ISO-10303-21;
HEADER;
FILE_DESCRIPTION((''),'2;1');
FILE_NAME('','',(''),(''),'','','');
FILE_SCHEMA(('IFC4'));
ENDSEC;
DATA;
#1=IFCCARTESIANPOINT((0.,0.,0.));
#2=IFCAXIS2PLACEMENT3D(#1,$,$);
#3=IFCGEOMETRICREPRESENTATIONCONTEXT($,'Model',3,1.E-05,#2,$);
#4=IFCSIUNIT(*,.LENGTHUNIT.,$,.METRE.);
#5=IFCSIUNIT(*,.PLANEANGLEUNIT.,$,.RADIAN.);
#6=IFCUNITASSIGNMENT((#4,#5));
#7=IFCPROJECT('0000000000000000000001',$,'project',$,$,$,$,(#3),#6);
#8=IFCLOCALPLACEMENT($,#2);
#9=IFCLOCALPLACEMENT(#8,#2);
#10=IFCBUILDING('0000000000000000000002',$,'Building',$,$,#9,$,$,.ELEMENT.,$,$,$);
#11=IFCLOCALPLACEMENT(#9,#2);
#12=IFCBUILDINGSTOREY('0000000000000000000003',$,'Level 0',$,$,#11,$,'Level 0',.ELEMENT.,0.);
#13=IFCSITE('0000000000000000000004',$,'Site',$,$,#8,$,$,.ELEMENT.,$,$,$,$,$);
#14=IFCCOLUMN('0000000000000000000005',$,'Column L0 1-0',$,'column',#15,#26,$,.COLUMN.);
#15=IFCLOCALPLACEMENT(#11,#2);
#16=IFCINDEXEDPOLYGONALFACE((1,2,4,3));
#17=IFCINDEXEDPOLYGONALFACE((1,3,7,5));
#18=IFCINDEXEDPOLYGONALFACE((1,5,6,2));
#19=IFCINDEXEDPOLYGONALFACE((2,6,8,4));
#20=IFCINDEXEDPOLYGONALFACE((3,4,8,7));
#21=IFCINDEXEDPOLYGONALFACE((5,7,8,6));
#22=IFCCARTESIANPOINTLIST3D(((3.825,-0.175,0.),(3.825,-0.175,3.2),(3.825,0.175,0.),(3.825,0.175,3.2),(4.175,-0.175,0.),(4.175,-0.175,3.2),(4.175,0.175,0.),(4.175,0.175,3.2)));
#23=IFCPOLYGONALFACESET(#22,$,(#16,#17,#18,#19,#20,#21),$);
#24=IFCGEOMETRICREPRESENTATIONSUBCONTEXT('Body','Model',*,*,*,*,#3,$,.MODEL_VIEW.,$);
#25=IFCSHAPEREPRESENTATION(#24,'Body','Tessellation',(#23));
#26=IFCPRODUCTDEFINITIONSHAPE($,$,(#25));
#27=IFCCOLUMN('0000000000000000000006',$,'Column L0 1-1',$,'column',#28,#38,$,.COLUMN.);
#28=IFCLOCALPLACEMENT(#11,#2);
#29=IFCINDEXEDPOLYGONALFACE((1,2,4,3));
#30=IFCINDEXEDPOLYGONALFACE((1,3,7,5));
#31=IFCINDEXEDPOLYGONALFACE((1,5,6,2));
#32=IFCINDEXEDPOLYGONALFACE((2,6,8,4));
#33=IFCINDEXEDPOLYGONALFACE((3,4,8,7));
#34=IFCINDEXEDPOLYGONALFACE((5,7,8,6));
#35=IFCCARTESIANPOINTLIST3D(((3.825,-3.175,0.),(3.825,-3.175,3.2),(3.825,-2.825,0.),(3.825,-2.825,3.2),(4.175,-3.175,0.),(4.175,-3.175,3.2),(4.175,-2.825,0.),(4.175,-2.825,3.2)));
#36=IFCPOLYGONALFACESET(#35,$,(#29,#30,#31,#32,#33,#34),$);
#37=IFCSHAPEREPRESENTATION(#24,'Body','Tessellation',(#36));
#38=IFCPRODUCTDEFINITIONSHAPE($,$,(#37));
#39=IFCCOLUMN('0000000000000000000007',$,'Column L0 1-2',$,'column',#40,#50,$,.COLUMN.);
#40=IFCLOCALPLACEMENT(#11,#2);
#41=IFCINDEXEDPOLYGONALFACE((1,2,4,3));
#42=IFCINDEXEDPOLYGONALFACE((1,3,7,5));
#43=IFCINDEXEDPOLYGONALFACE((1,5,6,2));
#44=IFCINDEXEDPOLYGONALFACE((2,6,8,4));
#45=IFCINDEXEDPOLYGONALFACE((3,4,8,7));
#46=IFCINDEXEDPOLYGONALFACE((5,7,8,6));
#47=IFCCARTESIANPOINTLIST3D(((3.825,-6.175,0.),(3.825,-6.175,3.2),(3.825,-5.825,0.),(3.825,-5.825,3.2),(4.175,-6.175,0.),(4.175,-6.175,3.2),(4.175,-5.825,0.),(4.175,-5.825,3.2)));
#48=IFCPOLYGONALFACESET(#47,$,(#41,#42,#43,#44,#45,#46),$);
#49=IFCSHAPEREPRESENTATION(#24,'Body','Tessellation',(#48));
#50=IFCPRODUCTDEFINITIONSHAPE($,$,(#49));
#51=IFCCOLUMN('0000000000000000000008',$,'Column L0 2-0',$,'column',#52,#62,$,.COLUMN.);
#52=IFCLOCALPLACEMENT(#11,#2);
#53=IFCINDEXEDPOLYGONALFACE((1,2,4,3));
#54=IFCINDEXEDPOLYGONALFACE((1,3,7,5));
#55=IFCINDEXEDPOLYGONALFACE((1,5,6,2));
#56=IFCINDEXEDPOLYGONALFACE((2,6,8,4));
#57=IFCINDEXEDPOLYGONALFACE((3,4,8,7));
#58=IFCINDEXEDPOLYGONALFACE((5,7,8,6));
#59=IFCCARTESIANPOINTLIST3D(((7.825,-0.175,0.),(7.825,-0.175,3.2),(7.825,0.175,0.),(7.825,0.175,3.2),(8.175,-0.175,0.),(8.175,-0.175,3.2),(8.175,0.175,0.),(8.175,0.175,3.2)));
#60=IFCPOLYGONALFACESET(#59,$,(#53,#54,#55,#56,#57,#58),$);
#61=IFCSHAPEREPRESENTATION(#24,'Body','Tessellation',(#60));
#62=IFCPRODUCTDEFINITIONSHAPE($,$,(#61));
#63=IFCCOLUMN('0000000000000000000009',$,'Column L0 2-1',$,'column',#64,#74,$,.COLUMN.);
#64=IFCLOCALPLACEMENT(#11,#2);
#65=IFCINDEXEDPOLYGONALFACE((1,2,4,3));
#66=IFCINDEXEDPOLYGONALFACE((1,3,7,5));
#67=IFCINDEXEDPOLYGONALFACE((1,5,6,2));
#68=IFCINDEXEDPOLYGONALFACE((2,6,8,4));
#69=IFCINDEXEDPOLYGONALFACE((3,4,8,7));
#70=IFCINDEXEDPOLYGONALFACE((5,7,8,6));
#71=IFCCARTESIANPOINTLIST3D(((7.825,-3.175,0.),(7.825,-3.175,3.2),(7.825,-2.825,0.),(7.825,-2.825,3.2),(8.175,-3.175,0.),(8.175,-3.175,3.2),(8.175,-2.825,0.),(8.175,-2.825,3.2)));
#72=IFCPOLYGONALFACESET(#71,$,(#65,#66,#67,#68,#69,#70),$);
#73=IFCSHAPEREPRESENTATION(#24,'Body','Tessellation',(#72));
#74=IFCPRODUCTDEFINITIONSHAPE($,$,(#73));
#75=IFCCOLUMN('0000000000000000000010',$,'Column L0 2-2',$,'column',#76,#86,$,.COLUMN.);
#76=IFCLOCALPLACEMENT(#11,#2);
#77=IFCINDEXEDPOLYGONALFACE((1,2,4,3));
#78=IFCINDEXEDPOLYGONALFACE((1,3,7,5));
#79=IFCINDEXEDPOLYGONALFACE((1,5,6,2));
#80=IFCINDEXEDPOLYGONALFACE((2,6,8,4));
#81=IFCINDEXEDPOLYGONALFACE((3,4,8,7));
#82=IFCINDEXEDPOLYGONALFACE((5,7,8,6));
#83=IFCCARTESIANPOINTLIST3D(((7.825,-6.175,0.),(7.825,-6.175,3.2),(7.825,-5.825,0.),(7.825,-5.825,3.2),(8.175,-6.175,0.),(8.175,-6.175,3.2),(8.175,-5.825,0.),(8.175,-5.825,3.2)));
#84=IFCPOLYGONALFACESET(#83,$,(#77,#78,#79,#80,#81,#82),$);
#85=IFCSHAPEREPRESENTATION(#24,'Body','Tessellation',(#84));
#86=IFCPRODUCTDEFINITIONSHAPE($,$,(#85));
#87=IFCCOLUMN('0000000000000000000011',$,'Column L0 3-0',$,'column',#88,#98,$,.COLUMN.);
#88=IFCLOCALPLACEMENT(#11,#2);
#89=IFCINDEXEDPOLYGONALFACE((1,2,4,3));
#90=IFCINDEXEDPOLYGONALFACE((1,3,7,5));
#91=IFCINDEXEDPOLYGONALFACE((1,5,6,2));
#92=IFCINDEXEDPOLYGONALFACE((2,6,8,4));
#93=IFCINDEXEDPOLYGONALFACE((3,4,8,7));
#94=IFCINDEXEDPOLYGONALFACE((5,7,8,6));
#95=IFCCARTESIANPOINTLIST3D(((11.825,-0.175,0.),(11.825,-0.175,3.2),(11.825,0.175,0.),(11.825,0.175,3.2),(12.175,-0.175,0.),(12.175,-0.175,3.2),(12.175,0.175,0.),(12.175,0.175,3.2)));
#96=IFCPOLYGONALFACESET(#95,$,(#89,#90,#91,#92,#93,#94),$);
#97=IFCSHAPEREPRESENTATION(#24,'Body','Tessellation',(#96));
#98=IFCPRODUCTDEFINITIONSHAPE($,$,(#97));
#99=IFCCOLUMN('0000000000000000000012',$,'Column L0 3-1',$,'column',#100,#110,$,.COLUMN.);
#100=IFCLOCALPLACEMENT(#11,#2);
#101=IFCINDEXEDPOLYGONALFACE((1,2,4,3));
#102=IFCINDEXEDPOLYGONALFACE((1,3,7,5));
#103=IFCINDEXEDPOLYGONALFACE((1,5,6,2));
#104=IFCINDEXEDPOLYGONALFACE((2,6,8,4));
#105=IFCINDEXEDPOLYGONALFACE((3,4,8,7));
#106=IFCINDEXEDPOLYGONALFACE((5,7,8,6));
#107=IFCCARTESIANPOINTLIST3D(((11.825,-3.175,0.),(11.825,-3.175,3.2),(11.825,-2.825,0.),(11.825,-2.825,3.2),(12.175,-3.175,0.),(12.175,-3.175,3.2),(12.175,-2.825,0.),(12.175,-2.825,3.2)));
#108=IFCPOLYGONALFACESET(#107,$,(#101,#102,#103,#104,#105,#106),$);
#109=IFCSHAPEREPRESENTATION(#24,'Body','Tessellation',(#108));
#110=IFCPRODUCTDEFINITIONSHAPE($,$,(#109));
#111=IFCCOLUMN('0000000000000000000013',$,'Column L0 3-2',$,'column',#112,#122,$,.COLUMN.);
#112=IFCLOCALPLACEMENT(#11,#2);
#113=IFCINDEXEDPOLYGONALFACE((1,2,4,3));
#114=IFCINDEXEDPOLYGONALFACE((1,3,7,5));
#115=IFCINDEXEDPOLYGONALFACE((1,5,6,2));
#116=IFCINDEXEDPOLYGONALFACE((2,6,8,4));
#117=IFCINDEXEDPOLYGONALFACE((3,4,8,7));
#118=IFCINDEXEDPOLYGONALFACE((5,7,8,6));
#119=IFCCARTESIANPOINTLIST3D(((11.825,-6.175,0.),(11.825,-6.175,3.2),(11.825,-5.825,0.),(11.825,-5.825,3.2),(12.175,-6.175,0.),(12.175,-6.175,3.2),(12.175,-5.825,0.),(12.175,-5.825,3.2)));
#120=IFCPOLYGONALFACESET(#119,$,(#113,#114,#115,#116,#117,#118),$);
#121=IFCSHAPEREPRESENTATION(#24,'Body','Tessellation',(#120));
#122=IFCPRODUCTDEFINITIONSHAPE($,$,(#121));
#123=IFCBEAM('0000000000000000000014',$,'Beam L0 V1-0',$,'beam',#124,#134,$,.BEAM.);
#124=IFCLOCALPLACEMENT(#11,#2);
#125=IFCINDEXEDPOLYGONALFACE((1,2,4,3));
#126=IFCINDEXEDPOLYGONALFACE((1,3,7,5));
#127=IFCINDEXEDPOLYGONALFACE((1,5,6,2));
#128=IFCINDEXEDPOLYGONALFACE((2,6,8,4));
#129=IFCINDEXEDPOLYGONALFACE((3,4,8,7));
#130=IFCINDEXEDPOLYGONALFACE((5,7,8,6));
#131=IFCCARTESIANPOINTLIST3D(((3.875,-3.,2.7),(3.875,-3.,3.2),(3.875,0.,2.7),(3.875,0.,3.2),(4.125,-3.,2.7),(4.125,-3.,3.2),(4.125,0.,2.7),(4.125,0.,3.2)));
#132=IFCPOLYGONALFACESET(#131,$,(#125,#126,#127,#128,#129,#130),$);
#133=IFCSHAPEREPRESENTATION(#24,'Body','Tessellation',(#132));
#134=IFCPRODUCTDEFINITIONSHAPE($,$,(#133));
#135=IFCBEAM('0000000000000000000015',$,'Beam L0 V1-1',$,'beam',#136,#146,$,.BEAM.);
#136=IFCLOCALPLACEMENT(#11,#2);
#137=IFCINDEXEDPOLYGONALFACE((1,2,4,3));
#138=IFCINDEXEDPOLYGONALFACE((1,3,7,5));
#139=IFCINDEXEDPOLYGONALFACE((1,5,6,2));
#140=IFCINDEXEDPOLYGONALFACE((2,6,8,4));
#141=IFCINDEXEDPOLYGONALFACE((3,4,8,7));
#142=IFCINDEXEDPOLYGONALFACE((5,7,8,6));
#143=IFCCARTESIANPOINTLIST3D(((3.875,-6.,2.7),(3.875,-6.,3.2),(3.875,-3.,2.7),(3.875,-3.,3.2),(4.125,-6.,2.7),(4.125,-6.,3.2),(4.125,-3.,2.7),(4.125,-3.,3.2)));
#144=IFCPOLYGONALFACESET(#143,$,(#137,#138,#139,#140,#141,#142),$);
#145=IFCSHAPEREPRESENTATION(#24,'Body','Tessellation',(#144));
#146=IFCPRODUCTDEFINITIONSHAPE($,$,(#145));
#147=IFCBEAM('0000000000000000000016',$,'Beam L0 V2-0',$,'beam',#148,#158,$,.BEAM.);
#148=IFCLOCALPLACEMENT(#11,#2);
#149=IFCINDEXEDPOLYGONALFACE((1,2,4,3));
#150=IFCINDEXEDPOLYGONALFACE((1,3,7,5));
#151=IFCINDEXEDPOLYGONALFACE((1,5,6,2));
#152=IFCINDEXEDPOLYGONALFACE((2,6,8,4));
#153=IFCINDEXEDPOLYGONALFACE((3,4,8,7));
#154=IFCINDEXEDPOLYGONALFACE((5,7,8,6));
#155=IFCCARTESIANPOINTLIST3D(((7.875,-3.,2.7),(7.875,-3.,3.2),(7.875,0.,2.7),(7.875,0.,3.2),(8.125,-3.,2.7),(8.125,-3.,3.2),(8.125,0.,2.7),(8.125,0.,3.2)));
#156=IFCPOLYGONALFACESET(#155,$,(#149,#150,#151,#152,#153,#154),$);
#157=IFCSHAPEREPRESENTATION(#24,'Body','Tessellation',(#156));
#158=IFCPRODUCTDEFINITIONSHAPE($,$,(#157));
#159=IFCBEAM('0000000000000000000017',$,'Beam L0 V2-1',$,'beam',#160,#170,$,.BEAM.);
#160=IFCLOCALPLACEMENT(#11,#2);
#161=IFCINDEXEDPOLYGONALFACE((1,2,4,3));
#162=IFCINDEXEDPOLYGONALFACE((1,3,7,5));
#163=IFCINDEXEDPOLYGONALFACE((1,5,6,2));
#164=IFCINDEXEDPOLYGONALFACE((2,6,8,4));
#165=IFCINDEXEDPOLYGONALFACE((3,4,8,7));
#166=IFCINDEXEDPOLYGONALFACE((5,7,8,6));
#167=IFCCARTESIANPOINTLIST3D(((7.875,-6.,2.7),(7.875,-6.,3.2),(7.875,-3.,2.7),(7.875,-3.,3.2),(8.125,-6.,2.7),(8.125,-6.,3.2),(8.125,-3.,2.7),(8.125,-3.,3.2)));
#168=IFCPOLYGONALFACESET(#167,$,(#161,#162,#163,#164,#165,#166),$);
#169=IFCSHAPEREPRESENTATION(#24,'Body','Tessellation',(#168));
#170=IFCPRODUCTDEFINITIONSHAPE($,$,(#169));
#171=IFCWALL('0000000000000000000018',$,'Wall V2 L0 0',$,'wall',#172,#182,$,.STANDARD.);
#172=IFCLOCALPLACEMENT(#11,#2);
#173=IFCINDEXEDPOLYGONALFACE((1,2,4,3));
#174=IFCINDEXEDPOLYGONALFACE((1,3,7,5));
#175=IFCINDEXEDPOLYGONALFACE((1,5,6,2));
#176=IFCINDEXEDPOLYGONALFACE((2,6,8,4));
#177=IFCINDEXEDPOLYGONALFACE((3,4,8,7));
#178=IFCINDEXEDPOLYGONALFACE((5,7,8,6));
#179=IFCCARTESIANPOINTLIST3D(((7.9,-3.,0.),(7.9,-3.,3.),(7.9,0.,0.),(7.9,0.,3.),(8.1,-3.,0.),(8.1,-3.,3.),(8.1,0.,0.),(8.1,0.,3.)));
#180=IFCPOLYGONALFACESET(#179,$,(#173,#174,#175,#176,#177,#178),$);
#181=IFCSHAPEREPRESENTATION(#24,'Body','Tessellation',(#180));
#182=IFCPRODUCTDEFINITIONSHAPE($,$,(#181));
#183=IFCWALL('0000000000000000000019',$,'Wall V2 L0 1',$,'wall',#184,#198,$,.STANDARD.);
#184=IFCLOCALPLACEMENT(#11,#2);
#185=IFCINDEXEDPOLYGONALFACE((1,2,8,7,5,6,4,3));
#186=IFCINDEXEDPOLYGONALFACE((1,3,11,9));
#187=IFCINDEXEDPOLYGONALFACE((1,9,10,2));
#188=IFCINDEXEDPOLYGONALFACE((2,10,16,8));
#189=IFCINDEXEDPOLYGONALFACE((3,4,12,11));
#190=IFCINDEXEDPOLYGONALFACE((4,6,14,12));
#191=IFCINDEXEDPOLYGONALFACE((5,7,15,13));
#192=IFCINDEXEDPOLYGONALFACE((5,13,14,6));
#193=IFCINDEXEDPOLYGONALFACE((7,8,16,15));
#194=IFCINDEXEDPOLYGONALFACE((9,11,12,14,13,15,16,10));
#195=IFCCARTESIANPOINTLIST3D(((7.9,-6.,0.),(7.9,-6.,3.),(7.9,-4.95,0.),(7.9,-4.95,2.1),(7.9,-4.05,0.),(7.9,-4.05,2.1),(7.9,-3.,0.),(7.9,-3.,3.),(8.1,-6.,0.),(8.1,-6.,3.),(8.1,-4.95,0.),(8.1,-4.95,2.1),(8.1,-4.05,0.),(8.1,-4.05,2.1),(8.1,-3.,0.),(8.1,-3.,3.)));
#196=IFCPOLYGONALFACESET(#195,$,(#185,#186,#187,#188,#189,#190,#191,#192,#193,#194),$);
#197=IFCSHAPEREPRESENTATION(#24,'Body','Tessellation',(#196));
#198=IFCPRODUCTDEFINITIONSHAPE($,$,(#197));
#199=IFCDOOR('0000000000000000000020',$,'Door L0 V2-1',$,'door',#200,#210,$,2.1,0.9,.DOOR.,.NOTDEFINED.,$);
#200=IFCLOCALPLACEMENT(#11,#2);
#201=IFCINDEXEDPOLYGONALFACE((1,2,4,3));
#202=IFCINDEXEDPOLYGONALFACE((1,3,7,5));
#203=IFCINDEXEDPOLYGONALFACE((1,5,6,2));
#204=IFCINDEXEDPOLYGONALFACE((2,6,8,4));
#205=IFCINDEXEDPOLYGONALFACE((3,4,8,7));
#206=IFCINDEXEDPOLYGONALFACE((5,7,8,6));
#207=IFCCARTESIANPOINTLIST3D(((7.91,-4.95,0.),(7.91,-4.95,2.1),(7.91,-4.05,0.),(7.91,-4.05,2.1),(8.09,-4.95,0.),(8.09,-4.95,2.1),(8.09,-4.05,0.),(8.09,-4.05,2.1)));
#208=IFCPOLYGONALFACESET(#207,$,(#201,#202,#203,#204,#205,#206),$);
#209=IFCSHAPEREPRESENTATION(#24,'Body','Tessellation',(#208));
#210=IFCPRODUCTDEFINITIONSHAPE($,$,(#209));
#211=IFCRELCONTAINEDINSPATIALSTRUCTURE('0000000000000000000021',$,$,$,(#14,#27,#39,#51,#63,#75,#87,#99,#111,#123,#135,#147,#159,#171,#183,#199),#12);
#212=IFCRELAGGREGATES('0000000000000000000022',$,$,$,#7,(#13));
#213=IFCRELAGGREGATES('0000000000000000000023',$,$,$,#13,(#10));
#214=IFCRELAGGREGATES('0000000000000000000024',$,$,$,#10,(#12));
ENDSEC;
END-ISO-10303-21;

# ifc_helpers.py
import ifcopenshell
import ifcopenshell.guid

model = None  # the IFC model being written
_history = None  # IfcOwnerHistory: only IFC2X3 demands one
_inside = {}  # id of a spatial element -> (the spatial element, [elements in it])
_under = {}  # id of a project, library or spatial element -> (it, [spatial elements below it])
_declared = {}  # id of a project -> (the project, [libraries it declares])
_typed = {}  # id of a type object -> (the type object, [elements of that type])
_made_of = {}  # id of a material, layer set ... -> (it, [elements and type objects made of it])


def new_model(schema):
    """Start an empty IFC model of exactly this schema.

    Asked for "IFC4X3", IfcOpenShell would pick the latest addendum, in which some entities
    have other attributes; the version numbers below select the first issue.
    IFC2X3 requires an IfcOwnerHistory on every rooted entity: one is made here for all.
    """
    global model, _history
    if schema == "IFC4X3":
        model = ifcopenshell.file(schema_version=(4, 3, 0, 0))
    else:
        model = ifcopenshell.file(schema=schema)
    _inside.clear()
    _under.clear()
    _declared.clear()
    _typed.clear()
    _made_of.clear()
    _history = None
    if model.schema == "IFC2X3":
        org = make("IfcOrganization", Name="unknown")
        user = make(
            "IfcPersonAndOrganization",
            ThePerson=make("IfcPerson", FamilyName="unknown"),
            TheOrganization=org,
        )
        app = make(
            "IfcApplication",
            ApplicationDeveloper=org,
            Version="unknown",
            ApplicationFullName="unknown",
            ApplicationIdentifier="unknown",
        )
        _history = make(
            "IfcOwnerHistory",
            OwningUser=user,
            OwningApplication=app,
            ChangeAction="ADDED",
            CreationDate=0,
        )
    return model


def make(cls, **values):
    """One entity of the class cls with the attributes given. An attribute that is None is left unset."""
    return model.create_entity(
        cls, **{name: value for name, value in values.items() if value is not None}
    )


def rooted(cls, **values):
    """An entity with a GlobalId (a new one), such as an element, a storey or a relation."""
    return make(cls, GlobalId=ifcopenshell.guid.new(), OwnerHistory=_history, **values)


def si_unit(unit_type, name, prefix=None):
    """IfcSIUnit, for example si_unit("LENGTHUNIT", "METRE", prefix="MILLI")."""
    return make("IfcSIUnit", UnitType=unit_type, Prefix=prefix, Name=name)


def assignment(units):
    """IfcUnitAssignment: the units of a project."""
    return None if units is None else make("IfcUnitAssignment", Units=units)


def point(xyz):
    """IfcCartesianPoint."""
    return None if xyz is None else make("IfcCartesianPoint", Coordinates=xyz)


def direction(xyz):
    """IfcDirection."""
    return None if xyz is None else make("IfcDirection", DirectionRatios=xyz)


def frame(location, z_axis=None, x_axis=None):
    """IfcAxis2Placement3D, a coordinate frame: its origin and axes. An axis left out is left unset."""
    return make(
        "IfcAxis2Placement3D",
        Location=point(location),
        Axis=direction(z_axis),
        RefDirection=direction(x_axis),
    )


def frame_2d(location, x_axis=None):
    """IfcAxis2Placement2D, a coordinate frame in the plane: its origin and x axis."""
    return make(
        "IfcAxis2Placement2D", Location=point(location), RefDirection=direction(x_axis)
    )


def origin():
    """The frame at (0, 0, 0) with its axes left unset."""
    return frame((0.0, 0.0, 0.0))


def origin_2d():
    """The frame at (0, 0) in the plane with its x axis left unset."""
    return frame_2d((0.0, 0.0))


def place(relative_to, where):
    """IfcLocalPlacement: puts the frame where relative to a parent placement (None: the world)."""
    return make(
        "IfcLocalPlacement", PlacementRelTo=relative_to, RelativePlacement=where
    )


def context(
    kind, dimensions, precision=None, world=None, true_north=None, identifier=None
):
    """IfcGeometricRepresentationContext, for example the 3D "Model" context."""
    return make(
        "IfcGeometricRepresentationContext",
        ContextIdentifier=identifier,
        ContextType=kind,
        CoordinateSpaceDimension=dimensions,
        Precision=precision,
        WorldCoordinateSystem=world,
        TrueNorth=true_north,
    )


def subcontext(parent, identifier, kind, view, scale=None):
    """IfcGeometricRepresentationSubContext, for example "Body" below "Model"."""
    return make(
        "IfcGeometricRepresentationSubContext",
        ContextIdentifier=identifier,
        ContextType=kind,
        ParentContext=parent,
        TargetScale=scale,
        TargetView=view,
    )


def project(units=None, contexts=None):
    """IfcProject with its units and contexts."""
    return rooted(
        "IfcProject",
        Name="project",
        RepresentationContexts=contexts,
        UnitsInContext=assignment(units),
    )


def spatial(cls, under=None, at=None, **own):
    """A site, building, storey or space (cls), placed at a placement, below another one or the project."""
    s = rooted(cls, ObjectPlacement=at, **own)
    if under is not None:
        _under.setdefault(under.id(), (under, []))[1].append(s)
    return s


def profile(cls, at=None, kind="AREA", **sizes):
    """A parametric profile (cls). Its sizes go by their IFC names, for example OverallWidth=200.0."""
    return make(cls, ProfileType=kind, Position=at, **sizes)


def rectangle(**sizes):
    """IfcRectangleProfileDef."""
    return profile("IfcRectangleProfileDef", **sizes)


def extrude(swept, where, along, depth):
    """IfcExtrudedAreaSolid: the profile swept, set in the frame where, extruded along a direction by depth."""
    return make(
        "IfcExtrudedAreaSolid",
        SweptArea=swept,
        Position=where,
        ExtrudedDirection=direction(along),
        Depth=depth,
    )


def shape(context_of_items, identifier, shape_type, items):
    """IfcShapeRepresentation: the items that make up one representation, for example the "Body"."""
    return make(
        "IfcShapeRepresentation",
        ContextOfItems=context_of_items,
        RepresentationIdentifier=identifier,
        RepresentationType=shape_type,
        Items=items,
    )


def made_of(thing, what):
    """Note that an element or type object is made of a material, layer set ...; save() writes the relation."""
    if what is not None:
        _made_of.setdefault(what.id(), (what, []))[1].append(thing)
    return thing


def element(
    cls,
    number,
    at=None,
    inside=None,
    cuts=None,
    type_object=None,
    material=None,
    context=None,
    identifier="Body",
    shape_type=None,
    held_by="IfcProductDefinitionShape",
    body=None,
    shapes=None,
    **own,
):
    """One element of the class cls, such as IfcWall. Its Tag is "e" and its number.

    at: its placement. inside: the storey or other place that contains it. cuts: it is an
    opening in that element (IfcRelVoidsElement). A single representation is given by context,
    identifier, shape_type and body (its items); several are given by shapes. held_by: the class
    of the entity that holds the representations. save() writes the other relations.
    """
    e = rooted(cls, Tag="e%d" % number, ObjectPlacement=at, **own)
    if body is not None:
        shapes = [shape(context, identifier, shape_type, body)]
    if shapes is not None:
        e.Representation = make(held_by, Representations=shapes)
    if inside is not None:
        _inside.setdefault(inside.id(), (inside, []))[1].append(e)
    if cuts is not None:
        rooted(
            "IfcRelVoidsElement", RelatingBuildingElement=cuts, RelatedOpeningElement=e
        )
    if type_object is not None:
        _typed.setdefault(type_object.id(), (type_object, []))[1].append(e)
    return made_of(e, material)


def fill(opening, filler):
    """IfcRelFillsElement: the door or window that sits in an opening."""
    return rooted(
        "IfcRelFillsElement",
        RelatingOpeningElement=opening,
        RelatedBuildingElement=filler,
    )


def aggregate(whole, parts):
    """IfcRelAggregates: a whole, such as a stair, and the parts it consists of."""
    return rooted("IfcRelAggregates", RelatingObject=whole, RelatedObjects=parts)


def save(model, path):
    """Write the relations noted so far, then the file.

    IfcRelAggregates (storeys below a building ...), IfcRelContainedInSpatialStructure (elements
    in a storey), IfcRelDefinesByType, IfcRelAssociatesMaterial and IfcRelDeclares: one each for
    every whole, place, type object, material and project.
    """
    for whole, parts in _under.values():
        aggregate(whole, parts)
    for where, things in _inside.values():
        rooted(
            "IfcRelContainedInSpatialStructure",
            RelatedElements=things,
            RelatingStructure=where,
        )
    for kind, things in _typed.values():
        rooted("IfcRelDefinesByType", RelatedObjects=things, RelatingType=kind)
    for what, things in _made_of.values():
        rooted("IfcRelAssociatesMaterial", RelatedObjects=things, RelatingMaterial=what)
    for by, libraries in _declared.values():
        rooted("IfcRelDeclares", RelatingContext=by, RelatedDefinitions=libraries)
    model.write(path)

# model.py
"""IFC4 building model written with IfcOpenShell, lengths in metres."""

from ifc_helpers import new_model, si_unit, frame, frame_2d, origin, origin_2d, place, context, subcontext, project, spatial, rectangle, extrude, element, fill, save


model = new_model("IFC4")

# Units and contexts
model_context = context("Model", 3, precision=1e-05, world=origin())
body_context = subcontext(model_context, "Body", "Model", "MODEL_VIEW")
ifc_project = project(units=[si_unit("LENGTHUNIT", "METRE"), si_unit("PLANEANGLEUNIT", "RADIAN")], contexts=[model_context])

# Site, building, storey
site_placement = place(None, origin())
site = spatial("IfcSite", under=ifc_project, at=site_placement, Name="Site", CompositionType="ELEMENT")
building_placement = place(site_placement, origin())
building = spatial("IfcBuilding", under=site, at=building_placement, Name="Building", CompositionType="ELEMENT")
storey_placement = place(building_placement, origin())
storey = spatial("IfcBuildingStorey", under=building, at=storey_placement, Name="Level 0", LongName="Level 0", CompositionType="ELEMENT", Elevation=0.0)

# Columns
for number, where, name in (
    (1, (4.0, 0.0, 0.0), "Column L0 1-0"),
    (2, (4.0, -3.0, 0.0), "Column L0 1-1"),
    (3, (4.0, -6.0, 0.0), "Column L0 1-2"),
    (4, (8.0, 0.0, 0.0), "Column L0 2-0"),
    (5, (8.0, -3.0, 0.0), "Column L0 2-1"),
    (6, (8.0, -6.0, 0.0), "Column L0 2-2"),
    (7, (12.0, 0.0, 0.0), "Column L0 3-0"),
    (8, (12.0, -3.0, 0.0), "Column L0 3-1"),
    (9, (12.0, -6.0, 0.0), "Column L0 3-2"),
):
    element("IfcColumn", number, at=place(storey_placement, frame(where)), inside=storey, Name=name, ObjectType="column", PredefinedType="COLUMN", context=body_context, shape_type="SweptSolid", body=[
        extrude(rectangle(XDim=0.35, YDim=0.35, at=origin_2d()), origin(), (0.0, 0.0, 1.0), 3.2),
    ])

# Beams
for number, where, z_axis, x_axis, name in (
    (10, (4.0, 0.0, 2.95), (0.0, -1.0, 0.0), (0.0, 0.0, 1.0), "Beam L0 V1-0"),
    (11, (4.0, -3.0, 2.95), (0.0, -1.0, 0.0), (0.0, 0.0, 1.0), "Beam L0 V1-1"),
    (12, (8.0, 0.0, 2.95), (0.0, -1.0, 0.0), (0.0, 0.0, 1.0), "Beam L0 V2-0"),
    (13, (8.0, -3.0, 2.95), (0.0, -1.0, 0.0), (0.0, 0.0, 1.0), "Beam L0 V2-1"),
):
    element("IfcBeam", number, at=place(storey_placement, frame(where, z_axis=z_axis, x_axis=x_axis)), inside=storey, Name=name, ObjectType="beam", PredefinedType="BEAM", context=body_context, shape_type="SweptSolid", body=[
        extrude(rectangle(XDim=0.5, YDim=0.25, at=origin_2d()), origin(), (0.0, 0.0, 1.0), 3.0),
    ])

# Wall
wall_1_placement = place(storey_placement, frame((8.0, 0.0, 0.0), z_axis=(0.0, 0.0, 1.0), x_axis=(0.0, -1.0, 0.0)))
element("IfcWall", 14, at=wall_1_placement, inside=storey, Name="Wall V2 L0 0", ObjectType="wall", PredefinedType="STANDARD", context=body_context, shape_type="SweptSolid", body=[
    extrude(rectangle(XDim=3.0, YDim=0.2, at=frame_2d((1.5, 0.0))), origin(), (0.0, 0.0, 1.0), 3.0),
])

# Wall, opening, door
wall_2_placement = place(storey_placement, frame((8.0, -3.0, 0.0), z_axis=(0.0, 0.0, 1.0), x_axis=(0.0, -1.0, 0.0)))
wall_2 = element("IfcWall", 15, at=wall_2_placement, inside=storey, Name="Wall V2 L0 1", ObjectType="wall", PredefinedType="STANDARD", context=body_context, shape_type="SweptSolid", body=[
    extrude(rectangle(XDim=3.0, YDim=0.2, at=frame_2d((1.5, 0.0))), origin(), (0.0, 0.0, 1.0), 3.0),
])
opening_1_placement = place(storey_placement, frame((8.0, -4.5, 0.0), z_axis=(0.0, 0.0, 1.0), x_axis=(0.0, -1.0, 0.0)))
opening_1 = element("IfcOpeningElement", 16, at=opening_1_placement, cuts=wall_2, ObjectType="Opening", PredefinedType="OPENING", context=body_context, shape_type="SweptSolid", body=[
    extrude(rectangle(XDim=0.9, YDim=0.22, at=origin_2d()), origin(), (0.0, 0.0, 1.0), 2.1),
])
door_1_placement = place(storey_placement, frame((8.0, -4.5, 0.0), z_axis=(0.0, 0.0, 1.0), x_axis=(0.0, -1.0, 0.0)))
door_1 = element("IfcDoor", 17, at=door_1_placement, inside=storey, Name="Door L0 V2-1", ObjectType="door", OperationType="NOTDEFINED", OverallHeight=2.1, OverallWidth=0.9, PredefinedType="DOOR", context=body_context, shape_type="SweptSolid", body=[
    extrude(rectangle(XDim=0.9, YDim=0.18, at=origin_2d()), origin(), (0.0, 0.0, 1.0), 2.1),
])
fill(opening_1, door_1)

save(model, "model.ifc")
